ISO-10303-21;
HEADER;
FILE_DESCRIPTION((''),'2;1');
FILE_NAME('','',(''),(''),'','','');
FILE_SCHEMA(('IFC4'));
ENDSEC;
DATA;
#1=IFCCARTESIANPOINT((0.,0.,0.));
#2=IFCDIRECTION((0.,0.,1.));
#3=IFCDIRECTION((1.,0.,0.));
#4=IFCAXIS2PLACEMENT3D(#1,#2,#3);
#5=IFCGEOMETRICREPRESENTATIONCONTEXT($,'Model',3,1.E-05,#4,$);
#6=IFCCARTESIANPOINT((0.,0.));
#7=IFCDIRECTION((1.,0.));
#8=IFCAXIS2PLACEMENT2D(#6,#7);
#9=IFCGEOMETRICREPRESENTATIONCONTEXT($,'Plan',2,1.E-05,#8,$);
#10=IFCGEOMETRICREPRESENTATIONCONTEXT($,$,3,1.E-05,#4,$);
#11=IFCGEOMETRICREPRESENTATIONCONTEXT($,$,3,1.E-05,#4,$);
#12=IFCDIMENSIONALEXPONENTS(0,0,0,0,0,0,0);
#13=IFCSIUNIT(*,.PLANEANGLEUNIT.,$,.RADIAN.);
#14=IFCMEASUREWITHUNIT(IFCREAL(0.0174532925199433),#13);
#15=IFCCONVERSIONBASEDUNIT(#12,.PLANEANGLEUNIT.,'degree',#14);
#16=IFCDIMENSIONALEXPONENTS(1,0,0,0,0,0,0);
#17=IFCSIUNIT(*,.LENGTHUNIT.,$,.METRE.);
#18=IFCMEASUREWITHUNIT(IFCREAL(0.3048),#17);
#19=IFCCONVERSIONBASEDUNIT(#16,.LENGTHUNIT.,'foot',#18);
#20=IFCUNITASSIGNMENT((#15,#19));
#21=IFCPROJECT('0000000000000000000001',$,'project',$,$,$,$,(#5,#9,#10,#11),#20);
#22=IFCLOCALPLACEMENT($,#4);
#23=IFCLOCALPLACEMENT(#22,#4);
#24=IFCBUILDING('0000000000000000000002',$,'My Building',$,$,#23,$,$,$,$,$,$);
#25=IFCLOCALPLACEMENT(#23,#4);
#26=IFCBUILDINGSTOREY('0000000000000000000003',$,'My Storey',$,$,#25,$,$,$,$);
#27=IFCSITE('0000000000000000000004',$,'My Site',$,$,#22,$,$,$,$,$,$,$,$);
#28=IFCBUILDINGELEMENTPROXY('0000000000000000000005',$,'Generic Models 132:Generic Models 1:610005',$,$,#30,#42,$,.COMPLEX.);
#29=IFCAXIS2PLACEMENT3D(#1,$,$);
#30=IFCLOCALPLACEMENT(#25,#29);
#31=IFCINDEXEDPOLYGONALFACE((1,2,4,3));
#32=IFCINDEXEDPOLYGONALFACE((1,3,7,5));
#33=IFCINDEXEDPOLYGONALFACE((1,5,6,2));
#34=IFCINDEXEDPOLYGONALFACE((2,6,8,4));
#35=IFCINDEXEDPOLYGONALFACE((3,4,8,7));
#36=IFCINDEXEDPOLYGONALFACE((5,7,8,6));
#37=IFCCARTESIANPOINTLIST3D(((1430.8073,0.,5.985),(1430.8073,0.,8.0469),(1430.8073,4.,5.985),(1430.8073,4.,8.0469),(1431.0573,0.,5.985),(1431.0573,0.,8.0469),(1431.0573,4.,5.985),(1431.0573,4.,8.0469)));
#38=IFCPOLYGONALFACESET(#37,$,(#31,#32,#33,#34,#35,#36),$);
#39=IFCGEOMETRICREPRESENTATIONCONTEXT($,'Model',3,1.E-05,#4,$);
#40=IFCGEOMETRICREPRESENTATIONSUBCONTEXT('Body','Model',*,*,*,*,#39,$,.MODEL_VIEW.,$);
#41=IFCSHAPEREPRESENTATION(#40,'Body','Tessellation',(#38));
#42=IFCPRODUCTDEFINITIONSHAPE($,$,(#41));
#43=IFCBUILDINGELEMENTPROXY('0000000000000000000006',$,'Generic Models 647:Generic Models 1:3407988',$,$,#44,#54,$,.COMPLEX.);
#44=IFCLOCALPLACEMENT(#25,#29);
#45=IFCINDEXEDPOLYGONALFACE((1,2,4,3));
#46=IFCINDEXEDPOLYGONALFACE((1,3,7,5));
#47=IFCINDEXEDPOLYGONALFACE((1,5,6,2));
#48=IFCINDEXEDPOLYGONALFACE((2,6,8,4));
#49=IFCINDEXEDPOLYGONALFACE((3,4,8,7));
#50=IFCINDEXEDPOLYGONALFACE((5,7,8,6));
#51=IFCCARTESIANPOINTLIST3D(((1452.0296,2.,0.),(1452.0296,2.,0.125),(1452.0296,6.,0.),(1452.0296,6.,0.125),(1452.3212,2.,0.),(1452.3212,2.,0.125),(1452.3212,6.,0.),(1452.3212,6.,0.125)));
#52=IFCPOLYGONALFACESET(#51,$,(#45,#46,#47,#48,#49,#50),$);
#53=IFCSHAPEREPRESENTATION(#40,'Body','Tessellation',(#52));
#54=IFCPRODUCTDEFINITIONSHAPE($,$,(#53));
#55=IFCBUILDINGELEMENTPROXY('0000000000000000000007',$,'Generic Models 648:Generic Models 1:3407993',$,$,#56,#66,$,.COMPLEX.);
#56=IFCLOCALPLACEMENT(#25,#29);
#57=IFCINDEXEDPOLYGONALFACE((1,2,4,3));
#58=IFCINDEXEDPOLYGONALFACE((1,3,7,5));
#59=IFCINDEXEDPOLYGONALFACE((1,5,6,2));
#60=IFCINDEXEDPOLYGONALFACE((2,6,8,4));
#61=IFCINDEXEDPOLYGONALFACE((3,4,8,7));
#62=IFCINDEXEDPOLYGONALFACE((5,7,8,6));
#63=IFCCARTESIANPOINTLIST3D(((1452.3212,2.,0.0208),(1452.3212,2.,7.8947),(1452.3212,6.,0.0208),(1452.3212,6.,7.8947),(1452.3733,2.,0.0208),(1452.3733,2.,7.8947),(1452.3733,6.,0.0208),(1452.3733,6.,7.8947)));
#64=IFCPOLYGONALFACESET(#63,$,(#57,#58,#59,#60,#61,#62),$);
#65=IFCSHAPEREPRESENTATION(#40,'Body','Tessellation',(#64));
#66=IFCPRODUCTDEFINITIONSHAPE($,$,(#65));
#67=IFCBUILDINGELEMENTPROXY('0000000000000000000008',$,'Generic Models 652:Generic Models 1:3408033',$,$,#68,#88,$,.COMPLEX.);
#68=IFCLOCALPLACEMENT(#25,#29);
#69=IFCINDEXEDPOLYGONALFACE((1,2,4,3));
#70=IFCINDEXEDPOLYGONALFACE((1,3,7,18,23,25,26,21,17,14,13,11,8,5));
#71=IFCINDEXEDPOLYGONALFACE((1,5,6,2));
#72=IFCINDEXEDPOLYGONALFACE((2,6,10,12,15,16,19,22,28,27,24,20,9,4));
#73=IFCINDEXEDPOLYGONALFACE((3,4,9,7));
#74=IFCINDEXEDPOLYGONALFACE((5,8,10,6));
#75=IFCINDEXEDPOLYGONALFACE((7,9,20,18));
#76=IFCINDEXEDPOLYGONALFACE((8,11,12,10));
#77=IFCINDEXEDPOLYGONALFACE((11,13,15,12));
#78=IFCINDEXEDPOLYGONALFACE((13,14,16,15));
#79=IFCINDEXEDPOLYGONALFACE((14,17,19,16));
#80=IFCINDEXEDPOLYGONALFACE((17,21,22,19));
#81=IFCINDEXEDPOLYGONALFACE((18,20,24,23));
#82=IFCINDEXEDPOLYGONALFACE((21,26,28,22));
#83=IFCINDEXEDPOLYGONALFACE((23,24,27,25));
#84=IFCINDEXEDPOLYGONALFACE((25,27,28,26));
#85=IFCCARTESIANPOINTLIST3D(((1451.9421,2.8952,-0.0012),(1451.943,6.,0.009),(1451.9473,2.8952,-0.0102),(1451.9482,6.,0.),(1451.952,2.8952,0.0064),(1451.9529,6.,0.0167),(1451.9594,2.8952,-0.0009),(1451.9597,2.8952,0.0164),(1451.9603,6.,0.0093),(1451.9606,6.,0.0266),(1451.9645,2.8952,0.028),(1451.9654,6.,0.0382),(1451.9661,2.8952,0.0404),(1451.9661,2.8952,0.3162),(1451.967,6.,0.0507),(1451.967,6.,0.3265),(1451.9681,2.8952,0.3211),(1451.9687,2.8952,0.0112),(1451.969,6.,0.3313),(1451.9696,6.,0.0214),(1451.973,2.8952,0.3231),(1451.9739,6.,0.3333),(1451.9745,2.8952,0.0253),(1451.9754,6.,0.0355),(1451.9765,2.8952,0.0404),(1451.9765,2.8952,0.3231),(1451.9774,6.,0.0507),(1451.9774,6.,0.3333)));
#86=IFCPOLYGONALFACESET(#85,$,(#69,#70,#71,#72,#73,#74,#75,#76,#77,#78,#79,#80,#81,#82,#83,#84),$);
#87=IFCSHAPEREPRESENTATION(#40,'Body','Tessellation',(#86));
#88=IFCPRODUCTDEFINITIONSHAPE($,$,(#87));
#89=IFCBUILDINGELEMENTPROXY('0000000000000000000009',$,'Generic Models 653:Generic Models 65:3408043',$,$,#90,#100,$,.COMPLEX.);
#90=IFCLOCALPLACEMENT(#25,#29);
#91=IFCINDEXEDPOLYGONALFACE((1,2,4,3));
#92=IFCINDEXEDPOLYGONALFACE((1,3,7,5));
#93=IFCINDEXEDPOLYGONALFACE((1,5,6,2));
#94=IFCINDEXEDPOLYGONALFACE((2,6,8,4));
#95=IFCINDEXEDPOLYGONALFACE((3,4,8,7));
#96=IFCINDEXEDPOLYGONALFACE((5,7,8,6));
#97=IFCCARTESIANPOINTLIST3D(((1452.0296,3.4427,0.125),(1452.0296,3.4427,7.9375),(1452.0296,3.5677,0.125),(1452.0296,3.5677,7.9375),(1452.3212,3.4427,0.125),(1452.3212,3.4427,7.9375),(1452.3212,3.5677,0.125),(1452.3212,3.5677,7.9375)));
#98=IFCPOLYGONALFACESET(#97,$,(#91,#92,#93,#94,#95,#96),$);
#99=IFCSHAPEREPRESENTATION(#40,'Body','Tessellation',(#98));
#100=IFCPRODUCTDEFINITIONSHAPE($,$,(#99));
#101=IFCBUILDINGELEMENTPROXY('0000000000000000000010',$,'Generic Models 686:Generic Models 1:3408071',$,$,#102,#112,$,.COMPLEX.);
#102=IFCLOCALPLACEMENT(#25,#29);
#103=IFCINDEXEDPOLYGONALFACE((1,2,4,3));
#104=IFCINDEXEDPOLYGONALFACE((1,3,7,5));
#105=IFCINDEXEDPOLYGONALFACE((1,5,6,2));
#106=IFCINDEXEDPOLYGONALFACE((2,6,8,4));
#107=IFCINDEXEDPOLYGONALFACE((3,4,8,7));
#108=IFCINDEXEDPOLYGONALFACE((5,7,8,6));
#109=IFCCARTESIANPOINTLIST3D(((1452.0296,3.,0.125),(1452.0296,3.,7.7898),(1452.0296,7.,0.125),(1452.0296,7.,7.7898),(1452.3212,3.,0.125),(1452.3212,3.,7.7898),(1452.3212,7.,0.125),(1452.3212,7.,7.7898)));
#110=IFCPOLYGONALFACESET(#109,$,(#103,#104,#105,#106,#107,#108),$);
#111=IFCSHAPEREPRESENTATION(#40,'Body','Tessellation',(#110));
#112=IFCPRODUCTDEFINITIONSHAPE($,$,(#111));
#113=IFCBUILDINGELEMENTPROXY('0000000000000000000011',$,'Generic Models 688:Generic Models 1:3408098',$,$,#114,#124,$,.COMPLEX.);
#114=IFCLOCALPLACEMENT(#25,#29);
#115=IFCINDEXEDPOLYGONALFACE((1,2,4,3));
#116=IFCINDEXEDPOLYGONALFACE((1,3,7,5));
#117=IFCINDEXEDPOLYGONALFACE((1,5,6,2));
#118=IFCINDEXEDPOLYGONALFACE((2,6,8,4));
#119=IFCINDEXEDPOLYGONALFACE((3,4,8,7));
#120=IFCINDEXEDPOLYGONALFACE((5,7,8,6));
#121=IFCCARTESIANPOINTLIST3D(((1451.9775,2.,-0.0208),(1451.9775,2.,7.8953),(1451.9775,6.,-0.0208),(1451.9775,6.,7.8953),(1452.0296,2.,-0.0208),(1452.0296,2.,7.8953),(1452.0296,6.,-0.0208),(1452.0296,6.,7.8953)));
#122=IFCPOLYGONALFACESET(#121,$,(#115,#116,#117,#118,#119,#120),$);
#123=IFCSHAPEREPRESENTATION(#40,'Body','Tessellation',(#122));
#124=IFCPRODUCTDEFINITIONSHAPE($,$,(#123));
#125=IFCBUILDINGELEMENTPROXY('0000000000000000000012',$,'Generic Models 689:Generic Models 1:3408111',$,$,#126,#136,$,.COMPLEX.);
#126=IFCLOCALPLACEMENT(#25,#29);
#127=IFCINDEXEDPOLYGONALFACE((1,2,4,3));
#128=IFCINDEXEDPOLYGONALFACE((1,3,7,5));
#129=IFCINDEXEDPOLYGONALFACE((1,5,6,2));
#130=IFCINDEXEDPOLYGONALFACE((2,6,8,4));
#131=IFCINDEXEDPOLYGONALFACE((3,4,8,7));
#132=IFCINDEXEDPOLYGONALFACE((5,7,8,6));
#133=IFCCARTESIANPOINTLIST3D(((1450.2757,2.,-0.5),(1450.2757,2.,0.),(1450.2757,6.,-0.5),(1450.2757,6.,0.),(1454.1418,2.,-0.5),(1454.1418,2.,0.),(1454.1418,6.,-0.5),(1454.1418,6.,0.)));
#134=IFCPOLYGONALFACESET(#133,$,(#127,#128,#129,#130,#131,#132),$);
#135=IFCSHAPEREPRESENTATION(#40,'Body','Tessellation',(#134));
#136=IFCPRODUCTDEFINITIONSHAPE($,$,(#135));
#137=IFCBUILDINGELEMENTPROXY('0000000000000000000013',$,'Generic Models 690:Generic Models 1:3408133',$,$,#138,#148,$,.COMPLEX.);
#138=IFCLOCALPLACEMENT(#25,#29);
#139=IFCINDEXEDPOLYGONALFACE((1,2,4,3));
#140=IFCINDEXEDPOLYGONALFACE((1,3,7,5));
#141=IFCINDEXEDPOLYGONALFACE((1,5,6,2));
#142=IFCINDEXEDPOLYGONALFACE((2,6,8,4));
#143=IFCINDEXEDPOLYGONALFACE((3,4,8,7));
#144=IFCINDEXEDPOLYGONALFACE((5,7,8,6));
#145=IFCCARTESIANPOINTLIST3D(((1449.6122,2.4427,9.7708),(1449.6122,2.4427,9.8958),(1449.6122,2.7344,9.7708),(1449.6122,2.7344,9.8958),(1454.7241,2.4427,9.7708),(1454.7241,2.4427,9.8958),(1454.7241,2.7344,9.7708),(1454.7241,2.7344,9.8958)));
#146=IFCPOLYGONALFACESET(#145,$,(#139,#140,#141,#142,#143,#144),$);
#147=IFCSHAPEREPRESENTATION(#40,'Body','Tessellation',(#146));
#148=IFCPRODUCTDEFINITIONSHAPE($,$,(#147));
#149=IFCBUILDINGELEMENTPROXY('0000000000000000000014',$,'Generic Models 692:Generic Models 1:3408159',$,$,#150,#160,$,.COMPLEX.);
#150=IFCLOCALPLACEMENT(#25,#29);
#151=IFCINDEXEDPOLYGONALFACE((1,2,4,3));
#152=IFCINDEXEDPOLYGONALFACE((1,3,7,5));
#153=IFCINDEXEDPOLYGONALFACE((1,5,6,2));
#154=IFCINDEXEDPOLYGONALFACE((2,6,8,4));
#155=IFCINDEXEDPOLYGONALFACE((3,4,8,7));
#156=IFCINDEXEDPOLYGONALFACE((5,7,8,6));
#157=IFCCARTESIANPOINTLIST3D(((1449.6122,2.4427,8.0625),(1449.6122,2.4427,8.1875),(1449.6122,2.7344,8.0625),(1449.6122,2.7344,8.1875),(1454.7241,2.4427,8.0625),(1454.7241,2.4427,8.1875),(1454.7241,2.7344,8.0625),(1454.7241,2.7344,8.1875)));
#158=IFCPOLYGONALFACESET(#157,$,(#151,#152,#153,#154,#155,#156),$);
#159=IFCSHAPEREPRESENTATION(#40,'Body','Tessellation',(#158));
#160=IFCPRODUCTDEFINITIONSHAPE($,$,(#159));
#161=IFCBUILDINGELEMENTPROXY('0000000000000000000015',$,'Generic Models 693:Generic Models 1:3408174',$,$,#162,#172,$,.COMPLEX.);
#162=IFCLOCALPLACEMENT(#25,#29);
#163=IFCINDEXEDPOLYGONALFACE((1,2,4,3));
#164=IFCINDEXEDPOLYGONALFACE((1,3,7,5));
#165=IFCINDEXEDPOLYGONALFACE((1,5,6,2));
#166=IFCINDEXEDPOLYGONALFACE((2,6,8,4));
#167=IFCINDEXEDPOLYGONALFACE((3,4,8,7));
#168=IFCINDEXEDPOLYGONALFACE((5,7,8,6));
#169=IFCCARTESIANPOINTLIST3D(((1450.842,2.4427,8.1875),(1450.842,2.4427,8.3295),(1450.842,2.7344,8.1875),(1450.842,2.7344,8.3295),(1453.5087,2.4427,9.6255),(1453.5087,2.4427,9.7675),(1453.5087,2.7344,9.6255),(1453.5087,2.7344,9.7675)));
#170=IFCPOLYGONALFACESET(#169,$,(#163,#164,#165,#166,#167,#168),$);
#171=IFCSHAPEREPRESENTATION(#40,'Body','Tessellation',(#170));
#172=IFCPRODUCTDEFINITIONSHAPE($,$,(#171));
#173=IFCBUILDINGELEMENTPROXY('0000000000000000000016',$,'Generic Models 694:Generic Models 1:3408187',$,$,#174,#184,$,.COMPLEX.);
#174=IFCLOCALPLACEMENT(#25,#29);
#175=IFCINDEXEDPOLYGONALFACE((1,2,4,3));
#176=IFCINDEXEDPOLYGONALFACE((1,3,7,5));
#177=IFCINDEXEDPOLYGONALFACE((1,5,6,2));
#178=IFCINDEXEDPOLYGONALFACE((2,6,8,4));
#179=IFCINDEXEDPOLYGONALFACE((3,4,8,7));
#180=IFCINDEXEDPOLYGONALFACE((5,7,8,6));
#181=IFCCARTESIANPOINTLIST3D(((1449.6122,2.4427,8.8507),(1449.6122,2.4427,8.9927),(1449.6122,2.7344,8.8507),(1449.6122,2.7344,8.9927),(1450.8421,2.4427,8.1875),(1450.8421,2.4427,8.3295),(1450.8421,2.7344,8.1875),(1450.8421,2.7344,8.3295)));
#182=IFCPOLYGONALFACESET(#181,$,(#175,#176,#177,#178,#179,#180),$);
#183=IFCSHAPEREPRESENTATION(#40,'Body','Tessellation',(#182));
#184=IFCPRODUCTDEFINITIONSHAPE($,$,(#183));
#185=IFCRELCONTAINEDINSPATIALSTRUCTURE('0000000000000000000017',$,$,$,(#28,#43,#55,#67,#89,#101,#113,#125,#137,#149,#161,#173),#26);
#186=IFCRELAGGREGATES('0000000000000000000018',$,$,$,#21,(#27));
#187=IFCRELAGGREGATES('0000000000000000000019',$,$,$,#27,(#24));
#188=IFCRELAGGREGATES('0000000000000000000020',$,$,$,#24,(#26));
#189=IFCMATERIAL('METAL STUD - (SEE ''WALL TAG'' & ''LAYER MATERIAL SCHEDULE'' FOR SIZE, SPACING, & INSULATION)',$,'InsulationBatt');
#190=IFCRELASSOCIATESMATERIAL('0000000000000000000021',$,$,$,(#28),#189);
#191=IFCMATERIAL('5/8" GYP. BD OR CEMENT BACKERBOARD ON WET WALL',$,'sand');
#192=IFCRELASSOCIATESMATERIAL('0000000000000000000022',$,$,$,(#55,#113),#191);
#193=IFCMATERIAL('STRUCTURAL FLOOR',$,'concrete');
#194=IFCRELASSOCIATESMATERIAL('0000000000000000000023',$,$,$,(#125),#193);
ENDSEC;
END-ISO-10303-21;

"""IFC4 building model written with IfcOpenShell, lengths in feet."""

from ifc_helpers import new_model, entity, si_unit, converted_unit, frame, origin_with_axes, origin_2d_with_axis, place, context, subcontext, project, spatial, polyline, outline, extrude, material, element, save


model = new_model("IFC4")

# Units and contexts
model_context_1 = context("Model", 3, precision=1e-05, world=origin_with_axes())
plan_context = context("Plan", 2, precision=1e-05, world=origin_2d_with_axis())
model_context_2 = context("Model", 3, precision=1e-05, world=origin_with_axes())
context_of_model_1 = context(None, 3, precision=1e-05, world=origin_with_axes())
context_of_model_2 = context(None, 3, precision=1e-05, world=origin_with_axes())
body_context = subcontext(model_context_2, "Body", "Model", "MODEL_VIEW")
ifc_project = project(units=[converted_unit("PLANEANGLEUNIT", "degree", entity("IfcReal", 0.0174532925199433), si_unit("PLANEANGLEUNIT", "RADIAN"), dimensions=[0, 0, 0, 0, 0, 0, 0]), converted_unit("LENGTHUNIT", "foot", entity("IfcReal", 0.3048), si_unit("LENGTHUNIT", "METRE"), dimensions=[1, 0, 0, 0, 0, 0, 0])], contexts=[model_context_1, plan_context, context_of_model_1, context_of_model_2])

# Site, building, storey
site_placement = place(None, origin_with_axes())
site = spatial("IfcSite", under=ifc_project, at=site_placement, Name="My Site")
building_placement = place(site_placement, origin_with_axes())
building = spatial("IfcBuilding", under=site, at=building_placement, Name="My Building")
storey_placement = place(building_placement, origin_with_axes())
storey = spatial("IfcBuildingStorey", under=building, at=storey_placement, Name="My Storey")

# Building element proxies
ifc_material_1 = material(Name="METAL STUD - (SEE 'WALL TAG' & 'LAYER MATERIAL SCHEDULE' FOR SIZE, SPACING, & INSULATION)", Category="InsulationBatt")
proxy_1_placement = place(storey_placement, frame((1430.8073, 4.0, 5.985), z_axis=(0.0, -1.0, 0.0), x_axis=(0.0, 0.0, 1.0)))
element("IfcBuildingElementProxy", 1, at=proxy_1_placement, inside=storey, material=ifc_material_1, Name="Generic Models 132:Generic Models 1:610005", PredefinedType="COMPLEX", context=body_context, shape_type="SweptSolid", body=[
    extrude(outline(polyline([(-1.0309, -0.125), (1.0309, -0.125), (1.0309, 0.125), (-1.0309, 0.125), (-1.0309, -0.125)])), frame((1.0309, -0.125, 0.0), z_axis=(0.0, 0.0, -1.0), x_axis=(1.0, 0.0, 0.0)), (0.0, 0.0, -1.0), 4.0),
])
proxy_2_placement = place(storey_placement, frame((1452.0296, 6.0, 0.0), z_axis=(0.0, -1.0, 0.0), x_axis=(0.0, 0.0, 1.0)))
element("IfcBuildingElementProxy", 2, at=proxy_2_placement, inside=storey, Name="Generic Models 647:Generic Models 1:3407988", PredefinedType="COMPLEX", context=body_context, shape_type="SweptSolid", body=[
    extrude(outline(polyline([(-0.0625, -0.1458), (0.0625, -0.1458), (0.0625, 0.1458), (-0.0625, 0.1458), (-0.0625, -0.1458)])), frame((0.0625, -0.1458, 0.0), z_axis=(0.0, 0.0, -1.0), x_axis=(1.0, 0.0, 0.0)), (0.0, 0.0, -1.0), 4.0),
])
ifc_material_2 = material(Name="5/8\" GYP. BD OR CEMENT BACKERBOARD ON WET WALL", Category="sand")
proxy_3_placement = place(storey_placement, frame((1452.3212, 6.0, 0.0208), z_axis=(0.0, -1.0, 0.0), x_axis=(0.0, 0.0, 1.0)))
element("IfcBuildingElementProxy", 3, at=proxy_3_placement, inside=storey, material=ifc_material_2, Name="Generic Models 648:Generic Models 1:3407993", PredefinedType="COMPLEX", context=body_context, shape_type="SweptSolid", body=[
    extrude(outline(polyline([(-3.9369, -0.026), (3.9369, -0.026), (3.9369, 0.026), (-3.9369, 0.026), (-3.9369, -0.026)])), frame((3.9369, -0.026, 0.0), z_axis=(0.0, 0.0, -1.0), x_axis=(1.0, 0.0, 0.0)), (0.0, 0.0, -1.0), 4.0),
])
proxy_4_placement = place(storey_placement, frame((1451.943, 6.0, 0.0), z_axis=(0.0, -1.0, 0.0), x_axis=(0.0, 0.0, 1.0)))
element("IfcBuildingElementProxy", 4, at=proxy_4_placement, inside=storey, Name="Generic Models 652:Generic Models 1:3408033", PredefinedType="COMPLEX", context=body_context, shape_type="SweptSolid", body=[
    extrude(outline(polyline([(-0.0624, 0.0022), (0.2134, 0.0022), (0.2183, 0.0042), (0.2203, 0.0091), (0.2203, 0.0126), (-0.0624, 0.0126), (-0.0775, 0.0106), (-0.0916, 0.0048), (-0.1037, -0.0045), (-0.113, -0.0166), (-0.104, -0.0218), (-0.0964, -0.0119), (-0.0864, -0.0042), (-0.0748, 0.0006), (-0.0624, 0.0022)])), frame((0.113, -0.0218, 0.0), z_axis=(0.0, 0.0, -1.0), x_axis=(1.0, 0.0, 0.0)), (-0.003299, -0.000291, -0.999995), 3.1048),
])
proxy_5_placement = place(storey_placement, frame((1452.0296, 3.4427, 0.125), z_axis=(0.0, 0.0, 1.0), x_axis=(1.0, 0.0, 0.0)))
element("IfcBuildingElementProxy", 5, at=proxy_5_placement, inside=storey, Name="Generic Models 653:Generic Models 65:3408043", PredefinedType="COMPLEX", context=body_context, shape_type="SweptSolid", body=[
    extrude(outline(polyline([(-0.1458, -0.0625), (0.1458, -0.0625), (0.1458, 0.0625), (-0.1458, 0.0625), (-0.1458, -0.0625)])), frame((0.1458, 0.0625, 0.0), z_axis=(0.0, 0.0, -1.0), x_axis=(-1.0, 0.0, 0.0)), (0.0, 0.0, -1.0), 7.8125),
])
proxy_6_placement = place(storey_placement, frame((1452.0296, 7.0, 0.125), z_axis=(0.0, -1.0, 0.0), x_axis=(0.0, 0.0, 1.0)))
element("IfcBuildingElementProxy", 6, at=proxy_6_placement, inside=storey, Name="Generic Models 686:Generic Models 1:3408071", PredefinedType="COMPLEX", context=body_context, shape_type="SweptSolid", body=[
    extrude(outline(polyline([(-3.8324, -0.1458), (3.8324, -0.1458), (3.8324, 0.1458), (-3.8324, 0.1458), (-3.8324, -0.1458)])), frame((3.8324, -0.1458, 0.0), z_axis=(0.0, 0.0, -1.0), x_axis=(1.0, 0.0, 0.0)), (0.0, 0.0, -1.0), 4.0),
])
proxy_7_placement = place(storey_placement, frame((1451.9775, 6.0, -0.0208), z_axis=(0.0, -1.0, 0.0), x_axis=(0.0, 0.0, 1.0)))
element("IfcBuildingElementProxy", 7, at=proxy_7_placement, inside=storey, material=ifc_material_2, Name="Generic Models 688:Generic Models 1:3408098", PredefinedType="COMPLEX", context=body_context, shape_type="SweptSolid", body=[
    extrude(outline(polyline([(-3.9581, -0.026), (3.9581, -0.026), (3.9581, 0.026), (-3.9581, 0.026), (-3.9581, -0.026)])), frame((3.9581, -0.026, 0.0), z_axis=(0.0, 0.0, -1.0), x_axis=(1.0, 0.0, 0.0)), (0.0, 0.0, -1.0), 4.0),
])
ifc_material_3 = material(Name="STRUCTURAL FLOOR", Category="concrete")
proxy_8_placement = place(storey_placement, frame((1450.2757, 6.0, -0.5), z_axis=(0.0, -1.0, 0.0), x_axis=(0.0, 0.0, 1.0)))
element("IfcBuildingElementProxy", 8, at=proxy_8_placement, inside=storey, material=ifc_material_3, Name="Generic Models 689:Generic Models 1:3408111", PredefinedType="COMPLEX", context=body_context, shape_type="SweptSolid", body=[
    extrude(outline(polyline([(-0.25, -1.9331), (0.25, -1.9331), (0.25, 1.9331), (-0.25, 1.9331), (-0.25, -1.9331)])), frame((0.25, -1.9331, 0.0), z_axis=(0.0, 0.0, -1.0), x_axis=(1.0, 0.0, 0.0)), (0.0, 0.0, -1.0), 4.0),
])
for number, where, z_axis, x_axis, name in (
    (9, (1449.6122, 2.7344, 9.7708), (0.0, -1.0, 0.0), (1.0, 0.0, 0.0), "Generic Models 690:Generic Models 1:3408133"),
    (10, (1449.6122, 2.7344, 8.0625), (0.0, -1.0, 0.0), (1.0, 0.0, 0.0), "Generic Models 692:Generic Models 1:3408159"),
):
    element("IfcBuildingElementProxy", number, at=place(storey_placement, frame(where, z_axis=z_axis, x_axis=x_axis)), inside=storey, Name=name, PredefinedType="COMPLEX", context=body_context, shape_type="SweptSolid", body=[
        extrude(outline(polyline([(-0.0625, -2.556), (0.0625, -2.556), (0.0625, 2.556), (-0.0625, 2.556), (-0.0625, -2.556)])), frame((2.556, 0.0625, 0.0), z_axis=(0.0, 0.0, -1.0), x_axis=(0.0, 1.0, 0.0)), (0.0, 0.0, -1.0), 0.2917),
    ])
proxy_9_placement = place(storey_placement, frame((1450.842, 2.7344, 8.1875), z_axis=(0.0, -1.0, 0.0), x_axis=(1.0, 0.0, 0.0)))
element("IfcBuildingElementProxy", 11, at=proxy_9_placement, inside=storey, Name="Generic Models 693:Generic Models 1:3408174", PredefinedType="COMPLEX", context=body_context, shape_type="SweptSolid", body=[
    extrude(outline(polyline([(-0.79, -1.3333), (-0.648, -1.3333), (0.79, 1.3333), (0.648, 1.3333), (-0.79, -1.3333)])), frame((1.3333, 0.79, 0.0), z_axis=(0.0, 0.0, -1.0), x_axis=(0.0, -1.0, 0.0)), (0.0, 0.0, -1.0), 0.2917),
])
proxy_10_placement = place(storey_placement, frame((1449.6122, 2.7344, 8.1875), z_axis=(0.0, -1.0, 0.0), x_axis=(1.0, 0.0, 0.0)))
element("IfcBuildingElementProxy", 12, at=proxy_10_placement, inside=storey, Name="Generic Models 694:Generic Models 1:3408187", PredefinedType="COMPLEX", context=body_context, shape_type="SweptSolid", body=[
    extrude(outline(polyline([(0.2606, -0.6149), (0.4026, -0.6149), (-0.2606, 0.6149), (-0.4026, 0.6149), (0.2606, -0.6149)])), frame((0.6149, 0.4026, 0.0), z_axis=(0.0, 0.0, -1.0), x_axis=(0.0, 1.0, 0.0)), (0.0, 0.0, -1.0), 0.2917),
])

save(model, "model.ifc")
